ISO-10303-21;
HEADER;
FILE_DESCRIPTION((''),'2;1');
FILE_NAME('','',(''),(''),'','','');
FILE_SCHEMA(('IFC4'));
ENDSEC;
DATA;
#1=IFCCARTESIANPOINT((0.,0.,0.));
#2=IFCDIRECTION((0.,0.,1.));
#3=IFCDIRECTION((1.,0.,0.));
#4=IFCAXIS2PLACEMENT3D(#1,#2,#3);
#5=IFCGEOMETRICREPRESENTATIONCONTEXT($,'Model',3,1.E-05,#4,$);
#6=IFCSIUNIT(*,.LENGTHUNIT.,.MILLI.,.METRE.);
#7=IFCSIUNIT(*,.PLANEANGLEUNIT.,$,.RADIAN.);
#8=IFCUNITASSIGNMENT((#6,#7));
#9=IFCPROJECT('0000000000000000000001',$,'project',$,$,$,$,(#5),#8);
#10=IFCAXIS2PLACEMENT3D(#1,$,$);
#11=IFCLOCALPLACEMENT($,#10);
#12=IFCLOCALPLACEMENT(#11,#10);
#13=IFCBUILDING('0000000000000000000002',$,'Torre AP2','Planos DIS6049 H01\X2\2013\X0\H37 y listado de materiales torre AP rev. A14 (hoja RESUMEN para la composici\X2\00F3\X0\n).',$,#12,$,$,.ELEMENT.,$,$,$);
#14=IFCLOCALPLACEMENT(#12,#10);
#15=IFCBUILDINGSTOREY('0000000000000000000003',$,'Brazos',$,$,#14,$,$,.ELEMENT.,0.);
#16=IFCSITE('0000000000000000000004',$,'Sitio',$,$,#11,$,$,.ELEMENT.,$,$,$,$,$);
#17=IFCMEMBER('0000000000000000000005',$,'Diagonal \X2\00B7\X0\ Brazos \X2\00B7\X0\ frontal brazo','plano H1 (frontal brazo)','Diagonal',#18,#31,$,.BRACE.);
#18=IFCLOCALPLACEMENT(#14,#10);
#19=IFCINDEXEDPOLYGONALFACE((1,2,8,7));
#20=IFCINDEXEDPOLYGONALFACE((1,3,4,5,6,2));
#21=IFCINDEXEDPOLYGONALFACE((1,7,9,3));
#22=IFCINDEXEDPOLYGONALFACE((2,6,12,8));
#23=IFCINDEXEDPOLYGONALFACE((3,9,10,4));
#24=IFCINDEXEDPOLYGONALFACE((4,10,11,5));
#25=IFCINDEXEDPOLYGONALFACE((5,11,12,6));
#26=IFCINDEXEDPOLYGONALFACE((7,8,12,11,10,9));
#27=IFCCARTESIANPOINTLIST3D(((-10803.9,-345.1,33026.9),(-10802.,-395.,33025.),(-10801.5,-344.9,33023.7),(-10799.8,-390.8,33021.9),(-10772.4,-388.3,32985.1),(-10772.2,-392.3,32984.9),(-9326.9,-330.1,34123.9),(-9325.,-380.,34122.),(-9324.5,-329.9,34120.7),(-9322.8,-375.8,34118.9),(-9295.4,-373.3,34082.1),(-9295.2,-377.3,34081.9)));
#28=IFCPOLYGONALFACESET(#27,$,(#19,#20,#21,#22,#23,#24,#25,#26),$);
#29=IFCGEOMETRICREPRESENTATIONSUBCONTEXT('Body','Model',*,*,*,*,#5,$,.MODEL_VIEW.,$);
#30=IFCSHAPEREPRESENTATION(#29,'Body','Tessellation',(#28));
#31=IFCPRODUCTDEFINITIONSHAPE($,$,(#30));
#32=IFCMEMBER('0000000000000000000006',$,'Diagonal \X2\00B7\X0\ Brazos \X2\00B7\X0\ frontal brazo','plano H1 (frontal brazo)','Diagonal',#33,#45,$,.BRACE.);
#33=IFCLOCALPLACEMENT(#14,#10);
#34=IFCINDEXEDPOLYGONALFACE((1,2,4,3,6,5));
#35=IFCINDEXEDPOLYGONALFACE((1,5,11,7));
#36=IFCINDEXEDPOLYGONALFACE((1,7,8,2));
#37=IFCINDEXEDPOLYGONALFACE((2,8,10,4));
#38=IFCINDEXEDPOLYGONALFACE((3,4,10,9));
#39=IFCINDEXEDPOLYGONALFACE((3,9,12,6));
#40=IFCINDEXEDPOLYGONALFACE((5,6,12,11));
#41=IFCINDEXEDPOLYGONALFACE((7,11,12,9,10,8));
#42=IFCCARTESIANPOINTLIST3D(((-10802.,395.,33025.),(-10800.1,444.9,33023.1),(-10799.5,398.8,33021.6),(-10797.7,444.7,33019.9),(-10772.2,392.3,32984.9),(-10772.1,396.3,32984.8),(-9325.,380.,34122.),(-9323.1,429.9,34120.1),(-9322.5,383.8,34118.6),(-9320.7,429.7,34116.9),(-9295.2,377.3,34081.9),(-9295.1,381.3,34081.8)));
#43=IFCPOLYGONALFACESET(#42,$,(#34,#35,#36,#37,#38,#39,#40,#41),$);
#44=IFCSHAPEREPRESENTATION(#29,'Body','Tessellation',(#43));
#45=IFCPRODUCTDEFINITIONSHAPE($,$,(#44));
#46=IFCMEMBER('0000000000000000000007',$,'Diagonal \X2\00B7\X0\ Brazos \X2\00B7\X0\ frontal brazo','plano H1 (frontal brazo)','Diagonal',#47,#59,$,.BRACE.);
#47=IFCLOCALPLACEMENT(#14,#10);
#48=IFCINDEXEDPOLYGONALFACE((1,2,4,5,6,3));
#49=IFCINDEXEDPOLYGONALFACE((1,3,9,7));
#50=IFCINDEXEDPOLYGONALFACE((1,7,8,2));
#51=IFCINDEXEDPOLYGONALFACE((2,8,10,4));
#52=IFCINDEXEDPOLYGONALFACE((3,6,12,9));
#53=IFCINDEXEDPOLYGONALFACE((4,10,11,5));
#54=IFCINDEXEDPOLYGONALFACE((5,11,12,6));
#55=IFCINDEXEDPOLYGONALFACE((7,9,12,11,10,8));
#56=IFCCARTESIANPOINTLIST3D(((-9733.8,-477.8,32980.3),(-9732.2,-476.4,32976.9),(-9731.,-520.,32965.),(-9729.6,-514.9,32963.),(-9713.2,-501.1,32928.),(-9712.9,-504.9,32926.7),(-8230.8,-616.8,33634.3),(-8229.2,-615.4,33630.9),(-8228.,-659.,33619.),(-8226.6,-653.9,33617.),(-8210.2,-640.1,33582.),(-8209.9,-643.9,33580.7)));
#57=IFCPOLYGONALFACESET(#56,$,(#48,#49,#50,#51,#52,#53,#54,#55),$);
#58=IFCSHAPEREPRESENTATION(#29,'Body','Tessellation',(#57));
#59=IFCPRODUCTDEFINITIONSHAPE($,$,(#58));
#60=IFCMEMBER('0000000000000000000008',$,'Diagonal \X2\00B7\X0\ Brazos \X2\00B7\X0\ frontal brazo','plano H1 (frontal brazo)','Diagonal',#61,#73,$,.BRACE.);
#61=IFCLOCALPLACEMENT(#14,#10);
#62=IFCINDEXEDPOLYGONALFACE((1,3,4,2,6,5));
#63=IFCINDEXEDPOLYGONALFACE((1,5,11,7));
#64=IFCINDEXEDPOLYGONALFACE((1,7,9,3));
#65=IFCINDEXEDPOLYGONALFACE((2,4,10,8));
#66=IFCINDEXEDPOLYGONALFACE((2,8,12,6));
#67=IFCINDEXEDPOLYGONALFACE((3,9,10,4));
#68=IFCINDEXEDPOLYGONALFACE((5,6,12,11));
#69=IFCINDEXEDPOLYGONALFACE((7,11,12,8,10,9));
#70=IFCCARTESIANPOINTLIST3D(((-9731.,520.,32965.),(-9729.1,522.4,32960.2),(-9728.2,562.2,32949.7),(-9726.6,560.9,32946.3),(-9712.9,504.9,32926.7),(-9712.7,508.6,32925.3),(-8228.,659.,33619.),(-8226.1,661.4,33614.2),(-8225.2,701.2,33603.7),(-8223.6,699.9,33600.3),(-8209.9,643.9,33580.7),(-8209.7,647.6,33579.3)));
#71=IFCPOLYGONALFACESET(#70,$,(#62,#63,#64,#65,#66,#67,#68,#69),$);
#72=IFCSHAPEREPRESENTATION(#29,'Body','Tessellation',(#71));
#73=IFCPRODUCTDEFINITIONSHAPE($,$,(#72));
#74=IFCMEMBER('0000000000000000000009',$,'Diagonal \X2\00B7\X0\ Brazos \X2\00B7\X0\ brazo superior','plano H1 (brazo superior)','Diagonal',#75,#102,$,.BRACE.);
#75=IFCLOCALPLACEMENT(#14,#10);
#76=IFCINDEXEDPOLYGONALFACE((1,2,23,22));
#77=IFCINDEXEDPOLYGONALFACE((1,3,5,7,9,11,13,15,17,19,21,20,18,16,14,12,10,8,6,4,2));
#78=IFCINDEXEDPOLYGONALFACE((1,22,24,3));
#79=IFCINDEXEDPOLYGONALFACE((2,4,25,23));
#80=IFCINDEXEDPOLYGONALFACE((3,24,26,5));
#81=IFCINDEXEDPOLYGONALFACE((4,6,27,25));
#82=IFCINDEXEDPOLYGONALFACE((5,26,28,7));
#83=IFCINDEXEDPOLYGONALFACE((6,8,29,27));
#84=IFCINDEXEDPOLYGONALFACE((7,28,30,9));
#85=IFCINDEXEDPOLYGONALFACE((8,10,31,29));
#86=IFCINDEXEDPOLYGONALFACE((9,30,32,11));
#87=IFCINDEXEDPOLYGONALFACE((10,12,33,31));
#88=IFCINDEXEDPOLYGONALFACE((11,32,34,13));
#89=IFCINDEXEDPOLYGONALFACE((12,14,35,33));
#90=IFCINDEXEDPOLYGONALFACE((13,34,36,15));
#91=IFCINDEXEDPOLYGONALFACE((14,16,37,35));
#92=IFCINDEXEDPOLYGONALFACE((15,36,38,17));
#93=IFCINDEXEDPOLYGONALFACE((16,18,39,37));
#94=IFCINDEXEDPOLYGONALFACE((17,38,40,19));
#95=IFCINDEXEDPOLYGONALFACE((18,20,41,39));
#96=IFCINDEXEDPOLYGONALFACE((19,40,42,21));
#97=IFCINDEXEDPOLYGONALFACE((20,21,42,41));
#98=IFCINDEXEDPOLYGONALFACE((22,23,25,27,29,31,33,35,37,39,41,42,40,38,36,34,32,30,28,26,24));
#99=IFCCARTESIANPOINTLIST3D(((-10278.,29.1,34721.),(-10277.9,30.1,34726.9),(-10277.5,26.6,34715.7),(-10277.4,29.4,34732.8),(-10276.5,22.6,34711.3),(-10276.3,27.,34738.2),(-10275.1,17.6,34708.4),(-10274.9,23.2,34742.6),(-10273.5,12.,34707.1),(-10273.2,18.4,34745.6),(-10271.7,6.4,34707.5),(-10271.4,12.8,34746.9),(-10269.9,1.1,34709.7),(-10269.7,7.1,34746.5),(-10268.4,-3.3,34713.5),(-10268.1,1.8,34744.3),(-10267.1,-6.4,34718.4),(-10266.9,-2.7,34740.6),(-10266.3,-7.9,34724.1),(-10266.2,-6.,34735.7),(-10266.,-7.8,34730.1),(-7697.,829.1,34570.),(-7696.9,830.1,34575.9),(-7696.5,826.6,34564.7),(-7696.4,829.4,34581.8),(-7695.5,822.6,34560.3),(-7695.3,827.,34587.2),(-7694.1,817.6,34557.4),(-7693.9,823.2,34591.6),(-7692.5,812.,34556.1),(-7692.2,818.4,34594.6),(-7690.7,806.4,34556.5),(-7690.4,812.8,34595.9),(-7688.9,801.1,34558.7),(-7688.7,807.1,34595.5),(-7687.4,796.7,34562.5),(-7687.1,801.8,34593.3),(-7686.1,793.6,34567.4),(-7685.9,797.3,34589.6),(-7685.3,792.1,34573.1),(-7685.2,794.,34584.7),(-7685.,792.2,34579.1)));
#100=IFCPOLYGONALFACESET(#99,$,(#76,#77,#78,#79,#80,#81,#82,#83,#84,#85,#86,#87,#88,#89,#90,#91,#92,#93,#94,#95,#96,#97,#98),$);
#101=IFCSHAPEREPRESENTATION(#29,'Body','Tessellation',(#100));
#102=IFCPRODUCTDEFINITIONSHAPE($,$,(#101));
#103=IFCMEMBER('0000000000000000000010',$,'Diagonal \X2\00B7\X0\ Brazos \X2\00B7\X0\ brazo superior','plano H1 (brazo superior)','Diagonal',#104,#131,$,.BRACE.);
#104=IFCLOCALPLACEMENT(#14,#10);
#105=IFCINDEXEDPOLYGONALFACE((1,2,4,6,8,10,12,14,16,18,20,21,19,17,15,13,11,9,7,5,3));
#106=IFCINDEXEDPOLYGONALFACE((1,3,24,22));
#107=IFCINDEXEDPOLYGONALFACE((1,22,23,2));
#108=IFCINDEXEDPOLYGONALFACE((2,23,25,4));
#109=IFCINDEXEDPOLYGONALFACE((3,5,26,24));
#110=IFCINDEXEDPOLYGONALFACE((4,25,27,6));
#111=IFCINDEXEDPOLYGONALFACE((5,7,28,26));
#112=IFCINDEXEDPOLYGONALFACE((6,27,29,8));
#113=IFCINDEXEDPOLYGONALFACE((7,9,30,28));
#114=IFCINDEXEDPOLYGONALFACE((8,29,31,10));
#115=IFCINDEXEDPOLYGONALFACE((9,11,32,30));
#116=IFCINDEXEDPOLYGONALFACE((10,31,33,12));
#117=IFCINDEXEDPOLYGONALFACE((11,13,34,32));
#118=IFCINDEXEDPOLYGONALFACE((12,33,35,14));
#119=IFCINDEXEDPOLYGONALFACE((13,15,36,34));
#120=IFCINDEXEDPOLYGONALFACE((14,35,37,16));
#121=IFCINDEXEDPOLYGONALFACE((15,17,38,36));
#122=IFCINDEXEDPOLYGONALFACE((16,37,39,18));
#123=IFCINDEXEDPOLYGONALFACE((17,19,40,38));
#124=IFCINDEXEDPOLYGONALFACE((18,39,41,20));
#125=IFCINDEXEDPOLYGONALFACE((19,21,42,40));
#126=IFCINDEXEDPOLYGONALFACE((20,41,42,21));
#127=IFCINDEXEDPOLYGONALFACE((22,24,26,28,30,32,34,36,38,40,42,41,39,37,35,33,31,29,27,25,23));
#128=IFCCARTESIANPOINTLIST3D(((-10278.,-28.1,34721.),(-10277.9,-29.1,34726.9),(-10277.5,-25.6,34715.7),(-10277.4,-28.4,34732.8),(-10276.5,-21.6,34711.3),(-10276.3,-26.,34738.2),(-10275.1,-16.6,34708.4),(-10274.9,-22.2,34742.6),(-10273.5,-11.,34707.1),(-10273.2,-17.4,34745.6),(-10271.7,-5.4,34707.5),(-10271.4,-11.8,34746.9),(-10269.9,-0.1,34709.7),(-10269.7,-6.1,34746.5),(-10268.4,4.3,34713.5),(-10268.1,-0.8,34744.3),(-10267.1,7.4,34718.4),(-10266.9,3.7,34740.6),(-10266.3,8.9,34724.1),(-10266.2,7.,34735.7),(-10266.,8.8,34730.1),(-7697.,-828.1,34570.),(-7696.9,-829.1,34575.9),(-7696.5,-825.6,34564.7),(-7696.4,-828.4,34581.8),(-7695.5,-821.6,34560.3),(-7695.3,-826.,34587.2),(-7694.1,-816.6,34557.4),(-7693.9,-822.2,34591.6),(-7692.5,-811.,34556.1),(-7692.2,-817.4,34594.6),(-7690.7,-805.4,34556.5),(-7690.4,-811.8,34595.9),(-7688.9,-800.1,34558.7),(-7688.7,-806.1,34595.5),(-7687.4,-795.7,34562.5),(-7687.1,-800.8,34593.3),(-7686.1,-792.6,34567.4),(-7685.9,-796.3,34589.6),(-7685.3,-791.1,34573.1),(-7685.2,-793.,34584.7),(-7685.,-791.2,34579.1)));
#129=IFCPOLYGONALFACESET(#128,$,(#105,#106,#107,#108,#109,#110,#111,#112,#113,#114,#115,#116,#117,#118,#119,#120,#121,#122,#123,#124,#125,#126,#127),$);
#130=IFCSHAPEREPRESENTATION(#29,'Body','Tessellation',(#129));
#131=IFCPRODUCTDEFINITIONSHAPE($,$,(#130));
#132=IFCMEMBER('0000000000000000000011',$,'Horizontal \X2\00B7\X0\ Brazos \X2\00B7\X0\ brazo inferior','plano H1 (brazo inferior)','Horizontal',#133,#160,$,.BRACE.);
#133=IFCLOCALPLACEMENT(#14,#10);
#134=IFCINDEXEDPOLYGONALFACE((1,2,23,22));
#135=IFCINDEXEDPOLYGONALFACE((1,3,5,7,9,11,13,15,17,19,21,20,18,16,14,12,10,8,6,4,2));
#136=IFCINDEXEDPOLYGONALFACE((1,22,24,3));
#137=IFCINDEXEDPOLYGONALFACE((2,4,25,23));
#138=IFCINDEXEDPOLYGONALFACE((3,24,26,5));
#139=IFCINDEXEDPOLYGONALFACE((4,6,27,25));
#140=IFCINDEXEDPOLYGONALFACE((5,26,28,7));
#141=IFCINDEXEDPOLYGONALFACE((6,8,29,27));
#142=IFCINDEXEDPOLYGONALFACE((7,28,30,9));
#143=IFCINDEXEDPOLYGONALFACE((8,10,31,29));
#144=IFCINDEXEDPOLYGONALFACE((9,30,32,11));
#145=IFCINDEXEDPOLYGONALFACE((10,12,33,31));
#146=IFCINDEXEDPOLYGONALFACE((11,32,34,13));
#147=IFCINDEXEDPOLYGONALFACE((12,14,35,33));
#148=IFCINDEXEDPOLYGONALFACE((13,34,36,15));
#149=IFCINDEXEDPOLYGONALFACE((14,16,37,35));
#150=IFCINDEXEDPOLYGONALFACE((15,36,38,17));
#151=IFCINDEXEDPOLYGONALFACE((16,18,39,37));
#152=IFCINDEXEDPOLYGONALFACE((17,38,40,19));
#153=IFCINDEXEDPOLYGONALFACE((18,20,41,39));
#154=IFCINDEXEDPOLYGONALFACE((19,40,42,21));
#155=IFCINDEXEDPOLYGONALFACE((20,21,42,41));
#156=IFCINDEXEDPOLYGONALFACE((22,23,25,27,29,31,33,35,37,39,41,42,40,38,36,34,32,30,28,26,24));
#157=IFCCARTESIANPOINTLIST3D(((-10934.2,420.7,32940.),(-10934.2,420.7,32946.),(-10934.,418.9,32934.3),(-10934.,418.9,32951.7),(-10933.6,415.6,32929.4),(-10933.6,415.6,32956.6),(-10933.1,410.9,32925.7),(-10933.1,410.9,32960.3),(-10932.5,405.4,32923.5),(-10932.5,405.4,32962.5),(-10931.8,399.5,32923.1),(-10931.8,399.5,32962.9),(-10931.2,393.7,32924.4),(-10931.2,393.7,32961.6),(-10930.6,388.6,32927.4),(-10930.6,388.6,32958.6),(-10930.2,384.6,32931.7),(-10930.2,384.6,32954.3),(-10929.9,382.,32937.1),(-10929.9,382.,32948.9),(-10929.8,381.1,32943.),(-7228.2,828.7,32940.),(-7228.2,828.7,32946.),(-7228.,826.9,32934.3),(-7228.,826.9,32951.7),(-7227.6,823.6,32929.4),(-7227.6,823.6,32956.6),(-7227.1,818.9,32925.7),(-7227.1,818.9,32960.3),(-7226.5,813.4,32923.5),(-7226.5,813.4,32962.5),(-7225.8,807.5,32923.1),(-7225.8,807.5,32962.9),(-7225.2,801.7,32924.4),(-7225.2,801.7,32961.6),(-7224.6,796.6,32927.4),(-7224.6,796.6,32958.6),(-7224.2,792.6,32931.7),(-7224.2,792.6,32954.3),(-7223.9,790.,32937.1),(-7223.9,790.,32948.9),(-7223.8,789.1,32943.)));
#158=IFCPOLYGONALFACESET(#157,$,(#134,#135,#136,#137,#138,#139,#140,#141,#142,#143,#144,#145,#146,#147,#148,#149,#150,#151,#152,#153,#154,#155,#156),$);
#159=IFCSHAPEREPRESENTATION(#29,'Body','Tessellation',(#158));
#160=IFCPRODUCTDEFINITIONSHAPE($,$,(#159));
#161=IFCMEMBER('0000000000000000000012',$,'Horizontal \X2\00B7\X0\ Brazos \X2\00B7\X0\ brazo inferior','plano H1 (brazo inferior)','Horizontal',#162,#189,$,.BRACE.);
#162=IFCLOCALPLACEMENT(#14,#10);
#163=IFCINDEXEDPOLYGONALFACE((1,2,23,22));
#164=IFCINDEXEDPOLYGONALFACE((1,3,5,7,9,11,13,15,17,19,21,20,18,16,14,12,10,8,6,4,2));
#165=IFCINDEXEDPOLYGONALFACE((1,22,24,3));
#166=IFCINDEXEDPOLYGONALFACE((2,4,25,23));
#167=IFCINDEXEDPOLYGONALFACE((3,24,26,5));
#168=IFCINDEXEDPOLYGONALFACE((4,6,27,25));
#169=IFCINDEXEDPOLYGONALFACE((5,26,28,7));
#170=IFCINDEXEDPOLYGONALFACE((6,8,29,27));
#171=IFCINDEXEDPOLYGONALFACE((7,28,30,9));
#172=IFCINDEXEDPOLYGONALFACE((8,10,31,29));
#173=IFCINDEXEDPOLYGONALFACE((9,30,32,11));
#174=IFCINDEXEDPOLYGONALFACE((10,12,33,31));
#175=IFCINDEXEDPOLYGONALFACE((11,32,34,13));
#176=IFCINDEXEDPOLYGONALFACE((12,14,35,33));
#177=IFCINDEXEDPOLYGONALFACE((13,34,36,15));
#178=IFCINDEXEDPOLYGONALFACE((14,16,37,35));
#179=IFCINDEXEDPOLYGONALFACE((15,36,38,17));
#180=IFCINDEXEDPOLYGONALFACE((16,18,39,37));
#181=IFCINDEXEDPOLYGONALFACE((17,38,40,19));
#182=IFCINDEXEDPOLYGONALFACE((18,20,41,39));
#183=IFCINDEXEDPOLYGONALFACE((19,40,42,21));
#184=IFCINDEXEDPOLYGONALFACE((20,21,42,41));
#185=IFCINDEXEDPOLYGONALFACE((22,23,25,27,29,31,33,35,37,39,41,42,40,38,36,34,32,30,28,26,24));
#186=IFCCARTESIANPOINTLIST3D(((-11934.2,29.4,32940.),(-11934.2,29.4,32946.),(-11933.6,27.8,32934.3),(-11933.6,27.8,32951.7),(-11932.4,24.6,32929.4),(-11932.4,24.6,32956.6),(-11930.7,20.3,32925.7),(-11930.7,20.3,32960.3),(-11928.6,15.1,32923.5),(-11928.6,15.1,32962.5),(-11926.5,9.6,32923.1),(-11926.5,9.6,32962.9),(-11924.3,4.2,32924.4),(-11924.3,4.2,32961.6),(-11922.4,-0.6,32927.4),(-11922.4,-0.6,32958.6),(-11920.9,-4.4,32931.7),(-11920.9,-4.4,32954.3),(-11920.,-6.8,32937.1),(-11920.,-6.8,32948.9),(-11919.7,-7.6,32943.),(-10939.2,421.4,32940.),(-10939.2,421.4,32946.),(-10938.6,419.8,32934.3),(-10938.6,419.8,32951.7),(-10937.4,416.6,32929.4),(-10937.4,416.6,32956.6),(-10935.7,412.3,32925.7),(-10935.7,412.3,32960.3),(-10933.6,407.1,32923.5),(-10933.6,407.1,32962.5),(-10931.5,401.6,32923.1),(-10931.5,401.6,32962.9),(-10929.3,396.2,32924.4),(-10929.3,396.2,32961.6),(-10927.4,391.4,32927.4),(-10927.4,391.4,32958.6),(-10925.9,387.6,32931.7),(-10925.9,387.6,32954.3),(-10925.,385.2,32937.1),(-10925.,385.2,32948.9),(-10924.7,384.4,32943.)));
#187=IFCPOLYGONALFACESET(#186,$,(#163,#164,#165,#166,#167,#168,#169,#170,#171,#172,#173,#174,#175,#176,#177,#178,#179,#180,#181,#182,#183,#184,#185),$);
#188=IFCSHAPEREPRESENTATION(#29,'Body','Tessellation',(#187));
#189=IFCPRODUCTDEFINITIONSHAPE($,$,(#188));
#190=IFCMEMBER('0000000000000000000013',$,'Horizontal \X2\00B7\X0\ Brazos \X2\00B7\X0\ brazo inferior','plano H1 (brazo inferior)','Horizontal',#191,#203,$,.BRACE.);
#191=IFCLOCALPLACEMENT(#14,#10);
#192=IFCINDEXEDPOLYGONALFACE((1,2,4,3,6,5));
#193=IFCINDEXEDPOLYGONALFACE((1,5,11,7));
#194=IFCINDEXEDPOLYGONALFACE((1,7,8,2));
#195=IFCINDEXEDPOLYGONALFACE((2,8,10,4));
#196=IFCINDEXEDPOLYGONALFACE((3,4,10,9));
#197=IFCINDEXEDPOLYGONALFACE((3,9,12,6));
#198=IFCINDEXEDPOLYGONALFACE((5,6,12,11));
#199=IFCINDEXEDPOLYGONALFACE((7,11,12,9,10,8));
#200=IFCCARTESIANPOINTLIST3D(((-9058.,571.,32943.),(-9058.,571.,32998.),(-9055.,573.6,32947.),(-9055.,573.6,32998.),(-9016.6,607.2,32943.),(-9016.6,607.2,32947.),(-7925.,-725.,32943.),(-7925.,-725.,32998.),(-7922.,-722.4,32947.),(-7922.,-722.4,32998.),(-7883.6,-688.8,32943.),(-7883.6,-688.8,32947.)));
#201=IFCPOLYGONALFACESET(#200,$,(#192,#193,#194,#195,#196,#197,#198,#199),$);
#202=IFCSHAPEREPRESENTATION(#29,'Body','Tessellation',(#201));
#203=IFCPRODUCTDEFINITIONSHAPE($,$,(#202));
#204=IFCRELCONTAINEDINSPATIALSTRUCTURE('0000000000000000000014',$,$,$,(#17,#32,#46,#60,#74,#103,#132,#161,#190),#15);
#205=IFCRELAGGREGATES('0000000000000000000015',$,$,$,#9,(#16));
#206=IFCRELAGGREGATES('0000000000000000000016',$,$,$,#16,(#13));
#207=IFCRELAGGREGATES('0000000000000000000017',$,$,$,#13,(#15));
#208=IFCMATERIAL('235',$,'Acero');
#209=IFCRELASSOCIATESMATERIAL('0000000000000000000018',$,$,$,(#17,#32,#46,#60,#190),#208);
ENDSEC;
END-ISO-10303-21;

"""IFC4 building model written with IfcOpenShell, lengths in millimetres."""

from ifc_helpers import new_model, si_unit, frame, frame_2d, origin, origin_with_axes, place, context, subcontext, project, spatial, circle, l_section, extrude, material, element, save


model = new_model("IFC4")

# Units and contexts
model_context = context("Model", 3, precision=1e-05, world=origin_with_axes())
body_context = subcontext(model_context, "Body", "Model", "MODEL_VIEW")
ifc_project = project(units=[si_unit("LENGTHUNIT", "METRE", prefix="MILLI"), si_unit("PLANEANGLEUNIT", "RADIAN")], contexts=[model_context])

# Site, building, storey
site_placement = place(None, origin())
site = spatial("IfcSite", under=ifc_project, at=site_placement, Name="Sitio", CompositionType="ELEMENT")
building_placement = place(site_placement, origin())
building = spatial("IfcBuilding", under=site, at=building_placement, Name="Torre AP2", Description="Planos DIS6049 H01–H37 y listado de materiales torre AP rev. A14 (hoja RESUMEN para la composición).", CompositionType="ELEMENT")
storey_placement = place(building_placement, origin())
storey = spatial("IfcBuildingStorey", under=building, at=storey_placement, Name="Brazos", CompositionType="ELEMENT", Elevation=0.0)

# Members
ifc_material_1 = material(Name="235", Category="Acero")
for number, where, z_axis, x_axis, name in (
    (1, (-10802.0, -395.0, 33025.0), (0.802769, 0.008153, 0.596234), (0.595049, 0.053521, -0.801905), "Diagonal · Brazos · frontal brazo"),
    (2, (-10802.0, 395.0, 33025.0), (0.802769, -0.008153, 0.596234), (0.595049, -0.053521, -0.801905), "Diagonal · Brazos · frontal brazo"),
):
    element("IfcMember", number, at=place(storey_placement, frame(where, z_axis=z_axis, x_axis=x_axis)), inside=storey, material=ifc_material_1, Name=name, Description="plano H1 (frontal brazo)", ObjectType="Diagonal", PredefinedType="BRACE", context=body_context, shape_type="SweptSolid", body=[
        extrude(l_section(Depth=50.0, Width=50.0, Thickness=4.0, at=frame_2d((25.0, 25.0))), None, (0.0, 0.0, 1.0), 1839.9),
    ])
for number, where, z_axis, x_axis, name in (
    (3, (-9731.0, -520.0, 32965.0), (0.913674, -0.084498, 0.397567), (0.401755, 0.335963, -0.851893), "Diagonal · Brazos · frontal brazo"),
    (4, (-9731.0, 520.0, 32965.0), (0.913674, 0.084498, 0.397567), (0.401755, -0.335963, -0.851893), "Diagonal · Brazos · frontal brazo"),
):
    element("IfcMember", number, at=place(storey_placement, frame(where, z_axis=z_axis, x_axis=x_axis)), inside=storey, material=ifc_material_1, Name=name, Description="plano H1 (frontal brazo)", ObjectType="Diagonal", PredefinedType="BRACE", context=body_context, shape_type="SweptSolid", body=[
        extrude(l_section(Depth=45.0, Width=45.0, Thickness=4.0, at=frame_2d((22.5, 22.5))), None, (0.0, 0.0, 1.0), 1645.0),
    ])
for number, where, z_axis, x_axis, name in (
    (5, (-7691.0, 811.0, 34576.0), (-0.953681, -0.2956, 0.055795), (0.300728, -0.941427, 0.152572), "Diagonal · Brazos · brazo superior"),
    (6, (-10272.0, -10.0, 34727.0), (0.953681, -0.2956, -0.055795), (0.300729, 0.941418, 0.152624), "Diagonal · Brazos · brazo superior"),
):
    element("IfcMember", number, at=place(storey_placement, frame(where, z_axis=z_axis, x_axis=x_axis)), inside=storey, Name=name, Description="plano H1 (brazo superior)", ObjectType="Diagonal", PredefinedType="BRACE", context=body_context, shape_type="SweptSolid", body=[
        extrude(circle(Radius=20.0), None, (0.0, 0.0, 1.0), 2706.4),
    ])
member_1_placement = place(storey_placement, frame((-7226.0, 809.0, 32943.0), z_axis=(-0.993994, -0.109431, 0.0), x_axis=(0.109431, -0.993994, 0.0)))
element("IfcMember", 7, at=member_1_placement, inside=storey, Name="Horizontal · Brazos · brazo inferior", Description="plano H1 (brazo inferior)", ObjectType="Horizontal", PredefinedType="BRACE", context=body_context, shape_type="SweptSolid", body=[
    extrude(circle(Radius=20.0), None, (0.0, 0.0, 1.0), 3728.4),
])
member_2_placement = place(storey_placement, frame((-10932.0, 403.0, 32943.0), z_axis=(-0.930399, -0.366549, 0.0), x_axis=(0.366549, -0.930399, 0.0)))
element("IfcMember", 8, at=member_2_placement, inside=storey, Name="Horizontal · Brazos · brazo inferior", Description="plano H1 (brazo inferior)", ObjectType="Horizontal", PredefinedType="BRACE", context=body_context, shape_type="SweptSolid", body=[
    extrude(circle(Radius=20.0), None, (0.0, 0.0, 1.0), 1069.4),
])
member_3_placement = place(storey_placement, frame((-9058.0, 571.0, 32943.0), z_axis=(0.658176, -0.752865, 0.0), x_axis=(0.752865, 0.658176, 0.0)))
element("IfcMember", 9, at=member_3_placement, inside=storey, material=ifc_material_1, Name="Horizontal · Brazos · brazo inferior", Description="plano H1 (brazo inferior)", ObjectType="Horizontal", PredefinedType="BRACE", context=body_context, shape_type="SweptSolid", body=[
    extrude(l_section(Depth=55.0, Width=55.0, Thickness=4.0, at=frame_2d((27.5, 27.5))), None, (0.0, 0.0, 1.0), 1721.4),
])

save(model, "model.ifc")
